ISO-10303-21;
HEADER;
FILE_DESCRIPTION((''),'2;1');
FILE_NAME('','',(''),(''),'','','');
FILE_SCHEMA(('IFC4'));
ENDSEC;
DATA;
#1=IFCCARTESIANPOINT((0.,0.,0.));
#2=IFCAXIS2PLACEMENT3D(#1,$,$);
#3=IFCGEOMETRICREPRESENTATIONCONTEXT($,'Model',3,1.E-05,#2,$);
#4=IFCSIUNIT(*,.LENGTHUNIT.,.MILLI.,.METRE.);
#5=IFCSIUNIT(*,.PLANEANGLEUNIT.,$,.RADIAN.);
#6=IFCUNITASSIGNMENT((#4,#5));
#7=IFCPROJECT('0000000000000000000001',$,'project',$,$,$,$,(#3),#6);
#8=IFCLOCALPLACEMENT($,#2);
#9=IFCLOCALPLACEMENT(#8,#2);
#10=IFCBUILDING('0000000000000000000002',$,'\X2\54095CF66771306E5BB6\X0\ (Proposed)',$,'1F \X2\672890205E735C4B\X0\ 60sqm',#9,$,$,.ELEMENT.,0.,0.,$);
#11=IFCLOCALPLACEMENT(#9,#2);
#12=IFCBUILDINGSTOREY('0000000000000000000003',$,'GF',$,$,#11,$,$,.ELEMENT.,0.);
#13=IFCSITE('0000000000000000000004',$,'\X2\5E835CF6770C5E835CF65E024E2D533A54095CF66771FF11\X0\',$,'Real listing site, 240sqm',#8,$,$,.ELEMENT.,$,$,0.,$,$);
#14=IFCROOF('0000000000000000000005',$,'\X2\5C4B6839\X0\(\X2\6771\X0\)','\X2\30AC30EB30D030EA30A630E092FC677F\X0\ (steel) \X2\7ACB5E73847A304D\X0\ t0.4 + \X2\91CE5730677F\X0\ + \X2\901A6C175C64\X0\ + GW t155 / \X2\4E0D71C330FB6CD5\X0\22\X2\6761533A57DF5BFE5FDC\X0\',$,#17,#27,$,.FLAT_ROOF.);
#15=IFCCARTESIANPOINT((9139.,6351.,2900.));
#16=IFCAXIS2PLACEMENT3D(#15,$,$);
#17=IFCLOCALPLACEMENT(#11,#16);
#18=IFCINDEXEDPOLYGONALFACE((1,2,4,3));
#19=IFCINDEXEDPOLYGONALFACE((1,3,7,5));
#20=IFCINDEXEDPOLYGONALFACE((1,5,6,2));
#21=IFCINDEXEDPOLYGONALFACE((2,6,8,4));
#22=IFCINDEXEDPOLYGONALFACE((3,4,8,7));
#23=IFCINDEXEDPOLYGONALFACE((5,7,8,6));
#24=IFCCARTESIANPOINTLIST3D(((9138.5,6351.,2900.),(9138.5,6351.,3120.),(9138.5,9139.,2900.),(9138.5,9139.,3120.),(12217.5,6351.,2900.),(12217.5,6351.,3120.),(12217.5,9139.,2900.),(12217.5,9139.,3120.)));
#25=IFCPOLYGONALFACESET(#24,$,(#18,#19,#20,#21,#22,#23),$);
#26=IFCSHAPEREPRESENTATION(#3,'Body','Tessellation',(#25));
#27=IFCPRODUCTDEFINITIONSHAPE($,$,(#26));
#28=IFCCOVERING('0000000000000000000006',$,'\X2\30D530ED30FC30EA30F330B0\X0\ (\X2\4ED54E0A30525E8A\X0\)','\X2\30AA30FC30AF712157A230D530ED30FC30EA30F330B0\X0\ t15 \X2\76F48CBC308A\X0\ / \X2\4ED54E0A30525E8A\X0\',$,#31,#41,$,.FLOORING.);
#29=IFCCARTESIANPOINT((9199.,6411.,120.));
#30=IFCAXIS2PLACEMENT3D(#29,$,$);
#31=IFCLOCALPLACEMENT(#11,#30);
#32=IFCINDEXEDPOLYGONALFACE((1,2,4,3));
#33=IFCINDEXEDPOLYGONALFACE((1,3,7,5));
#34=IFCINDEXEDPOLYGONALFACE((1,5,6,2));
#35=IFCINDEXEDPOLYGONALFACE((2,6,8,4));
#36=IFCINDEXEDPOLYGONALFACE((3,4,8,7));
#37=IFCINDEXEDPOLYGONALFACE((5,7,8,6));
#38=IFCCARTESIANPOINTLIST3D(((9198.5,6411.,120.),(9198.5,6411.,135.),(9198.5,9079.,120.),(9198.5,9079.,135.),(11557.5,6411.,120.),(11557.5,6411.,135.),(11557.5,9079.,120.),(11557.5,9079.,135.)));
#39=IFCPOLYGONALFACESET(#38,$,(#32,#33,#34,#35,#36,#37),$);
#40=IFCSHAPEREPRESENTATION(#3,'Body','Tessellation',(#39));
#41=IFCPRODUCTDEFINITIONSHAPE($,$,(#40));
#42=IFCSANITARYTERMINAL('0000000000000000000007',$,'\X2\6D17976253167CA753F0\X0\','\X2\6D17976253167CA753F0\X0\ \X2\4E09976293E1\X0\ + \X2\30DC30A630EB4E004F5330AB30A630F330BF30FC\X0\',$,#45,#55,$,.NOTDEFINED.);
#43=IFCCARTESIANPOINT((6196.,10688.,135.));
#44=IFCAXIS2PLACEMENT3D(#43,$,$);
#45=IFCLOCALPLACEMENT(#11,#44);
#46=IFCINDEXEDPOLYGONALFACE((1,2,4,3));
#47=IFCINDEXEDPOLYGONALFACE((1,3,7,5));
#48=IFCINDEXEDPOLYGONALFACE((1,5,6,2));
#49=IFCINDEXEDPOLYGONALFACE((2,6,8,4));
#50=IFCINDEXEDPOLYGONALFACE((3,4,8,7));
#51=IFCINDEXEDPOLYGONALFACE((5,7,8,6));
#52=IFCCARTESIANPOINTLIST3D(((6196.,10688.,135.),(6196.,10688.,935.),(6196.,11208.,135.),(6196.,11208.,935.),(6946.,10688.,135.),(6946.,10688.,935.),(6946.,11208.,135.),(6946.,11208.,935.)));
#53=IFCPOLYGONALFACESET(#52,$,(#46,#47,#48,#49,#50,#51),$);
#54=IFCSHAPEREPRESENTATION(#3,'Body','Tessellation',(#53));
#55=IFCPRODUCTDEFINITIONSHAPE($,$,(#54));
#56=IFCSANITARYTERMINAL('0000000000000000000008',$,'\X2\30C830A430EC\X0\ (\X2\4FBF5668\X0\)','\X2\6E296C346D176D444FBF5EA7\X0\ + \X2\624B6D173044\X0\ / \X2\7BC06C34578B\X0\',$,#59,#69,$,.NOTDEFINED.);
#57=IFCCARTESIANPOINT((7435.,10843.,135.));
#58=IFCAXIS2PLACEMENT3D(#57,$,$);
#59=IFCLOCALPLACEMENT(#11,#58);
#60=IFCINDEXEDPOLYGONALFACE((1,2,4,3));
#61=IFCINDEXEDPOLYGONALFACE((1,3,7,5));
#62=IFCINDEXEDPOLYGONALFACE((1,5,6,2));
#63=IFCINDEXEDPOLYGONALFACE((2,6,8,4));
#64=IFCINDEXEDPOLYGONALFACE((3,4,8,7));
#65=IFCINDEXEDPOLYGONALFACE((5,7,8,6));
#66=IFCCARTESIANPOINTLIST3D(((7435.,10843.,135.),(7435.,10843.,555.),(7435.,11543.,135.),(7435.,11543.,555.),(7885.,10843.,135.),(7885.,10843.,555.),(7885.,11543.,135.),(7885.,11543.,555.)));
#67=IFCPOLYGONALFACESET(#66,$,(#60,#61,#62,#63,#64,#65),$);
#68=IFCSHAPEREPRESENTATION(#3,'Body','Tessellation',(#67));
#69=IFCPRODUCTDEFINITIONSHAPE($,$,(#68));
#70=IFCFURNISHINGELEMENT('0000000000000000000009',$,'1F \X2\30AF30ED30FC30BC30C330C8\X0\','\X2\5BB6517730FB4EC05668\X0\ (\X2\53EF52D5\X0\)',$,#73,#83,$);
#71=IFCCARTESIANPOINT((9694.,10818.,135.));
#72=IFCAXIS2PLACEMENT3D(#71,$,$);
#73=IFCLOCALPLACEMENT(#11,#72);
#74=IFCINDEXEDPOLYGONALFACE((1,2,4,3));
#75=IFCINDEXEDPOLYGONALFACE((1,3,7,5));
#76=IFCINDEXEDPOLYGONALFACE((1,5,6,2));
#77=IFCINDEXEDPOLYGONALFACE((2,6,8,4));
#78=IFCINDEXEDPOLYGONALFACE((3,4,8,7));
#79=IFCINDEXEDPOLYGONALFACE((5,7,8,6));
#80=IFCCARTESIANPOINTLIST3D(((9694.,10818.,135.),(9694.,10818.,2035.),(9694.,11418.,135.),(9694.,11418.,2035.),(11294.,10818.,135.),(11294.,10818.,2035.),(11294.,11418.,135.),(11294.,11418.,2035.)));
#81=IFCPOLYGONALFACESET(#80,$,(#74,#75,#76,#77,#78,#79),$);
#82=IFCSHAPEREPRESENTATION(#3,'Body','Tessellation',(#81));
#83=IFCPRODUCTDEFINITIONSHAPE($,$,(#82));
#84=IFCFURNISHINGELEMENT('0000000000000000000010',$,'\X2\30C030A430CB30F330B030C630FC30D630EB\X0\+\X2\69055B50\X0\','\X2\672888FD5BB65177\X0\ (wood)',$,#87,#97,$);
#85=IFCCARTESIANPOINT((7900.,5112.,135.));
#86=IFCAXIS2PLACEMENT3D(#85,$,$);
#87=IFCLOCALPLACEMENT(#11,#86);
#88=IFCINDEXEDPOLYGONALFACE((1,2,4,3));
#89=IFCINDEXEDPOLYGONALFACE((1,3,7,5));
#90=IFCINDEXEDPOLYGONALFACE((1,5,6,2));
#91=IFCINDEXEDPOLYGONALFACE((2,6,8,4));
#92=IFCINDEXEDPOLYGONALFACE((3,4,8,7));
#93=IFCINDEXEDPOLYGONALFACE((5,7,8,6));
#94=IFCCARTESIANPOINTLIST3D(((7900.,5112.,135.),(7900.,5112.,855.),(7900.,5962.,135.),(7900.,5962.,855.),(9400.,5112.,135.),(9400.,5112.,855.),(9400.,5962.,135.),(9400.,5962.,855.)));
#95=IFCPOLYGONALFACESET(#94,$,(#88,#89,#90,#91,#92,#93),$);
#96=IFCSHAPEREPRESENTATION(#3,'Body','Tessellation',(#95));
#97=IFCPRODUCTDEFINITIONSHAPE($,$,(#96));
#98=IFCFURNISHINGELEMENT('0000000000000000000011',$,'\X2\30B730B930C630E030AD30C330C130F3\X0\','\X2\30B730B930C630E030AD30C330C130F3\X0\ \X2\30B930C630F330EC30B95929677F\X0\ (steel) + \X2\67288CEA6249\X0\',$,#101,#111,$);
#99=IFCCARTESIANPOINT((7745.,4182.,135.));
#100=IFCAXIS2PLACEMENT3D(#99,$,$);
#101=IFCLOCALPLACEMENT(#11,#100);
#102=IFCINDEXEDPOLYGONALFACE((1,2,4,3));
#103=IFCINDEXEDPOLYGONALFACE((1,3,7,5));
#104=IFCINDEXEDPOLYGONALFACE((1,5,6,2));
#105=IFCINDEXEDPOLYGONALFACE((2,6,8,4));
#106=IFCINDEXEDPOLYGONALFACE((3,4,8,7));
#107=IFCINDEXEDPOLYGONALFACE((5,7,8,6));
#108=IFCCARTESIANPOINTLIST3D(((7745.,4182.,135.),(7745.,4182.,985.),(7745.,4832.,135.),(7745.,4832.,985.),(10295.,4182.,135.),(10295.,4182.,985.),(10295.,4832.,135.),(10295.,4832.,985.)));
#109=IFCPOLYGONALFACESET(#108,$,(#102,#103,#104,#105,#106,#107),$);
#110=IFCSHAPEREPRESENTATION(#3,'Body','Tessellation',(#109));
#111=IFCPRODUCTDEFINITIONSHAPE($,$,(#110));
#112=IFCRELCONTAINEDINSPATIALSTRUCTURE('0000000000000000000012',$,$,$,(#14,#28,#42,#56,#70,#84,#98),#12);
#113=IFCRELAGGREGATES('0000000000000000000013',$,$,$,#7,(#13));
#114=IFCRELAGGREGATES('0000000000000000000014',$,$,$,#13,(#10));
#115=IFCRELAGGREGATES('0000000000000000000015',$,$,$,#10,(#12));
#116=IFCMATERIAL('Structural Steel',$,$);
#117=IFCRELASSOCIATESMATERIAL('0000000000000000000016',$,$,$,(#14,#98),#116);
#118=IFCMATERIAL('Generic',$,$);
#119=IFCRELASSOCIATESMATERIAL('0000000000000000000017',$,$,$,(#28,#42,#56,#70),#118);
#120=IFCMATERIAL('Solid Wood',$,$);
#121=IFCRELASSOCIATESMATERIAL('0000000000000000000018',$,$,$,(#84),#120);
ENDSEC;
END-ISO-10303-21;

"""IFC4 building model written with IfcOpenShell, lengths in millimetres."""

from ifc_helpers import new_model, si_unit, frame, frame_2d, origin, place, context, project, spatial, rectangle, extrude, material, element, save


model = new_model("IFC4")

# Units and contexts
model_context = context("Model", 3, precision=1e-05, world=origin())
ifc_project = project(units=[si_unit("LENGTHUNIT", "METRE", prefix="MILLI"), si_unit("PLANEANGLEUNIT", "RADIAN")], contexts=[model_context])

# Site, building, storey
site_placement = place(None, origin())
site = spatial("IfcSite", under=ifc_project, at=site_placement, Name="広島県広島市中区吉島東１", ObjectType="Real listing site, 240sqm", CompositionType="ELEMENT", RefElevation=0.0)
building_placement = place(site_placement, origin())
building = spatial("IfcBuilding", under=site, at=building_placement, Name="吉島東の家 (Proposed)", ObjectType="1F 木造平屋 60sqm", CompositionType="ELEMENT", ElevationOfRefHeight=0.0, ElevationOfTerrain=0.0)
storey_placement = place(building_placement, origin())
storey = spatial("IfcBuildingStorey", under=building, at=storey_placement, Name="GF", CompositionType="ELEMENT", Elevation=0.0)

# Shared definitions
ifc_material_1 = material(Name="Solid Wood")

# Roof
ifc_material_2 = material(Name="Structural Steel")
roof_placement = place(storey_placement, frame((9139.0, 6351.0, 2900.0)))
element("IfcRoof", 1, at=roof_placement, inside=storey, material=ifc_material_2, Name="屋根(東)", Description="ガルバリウム鋼板 (steel) 立平葺き t0.4 + 野地板 + 通気層 + GW t155 / 不燃・法22条区域対応", PredefinedType="FLAT_ROOF", context=model_context, shape_type="SweptSolid", body=[
    extrude(rectangle(XDim=3079.0, YDim=2788.0, at=frame_2d((1539.0, 1394.0))), frame((9139.0, 6351.0, 2900.0)), (0.0, 0.0, 1.0), 220.0),
])

# Covering
ifc_material_3 = material(Name="Generic")
covering_placement = place(storey_placement, frame((9199.0, 6411.0, 120.0)))
element("IfcCovering", 2, at=covering_placement, inside=storey, material=ifc_material_3, Name="フローリング (仕上げ床)", Description="オーク無垢フローリング t15 直貼り / 仕上げ床", PredefinedType="FLOORING", context=model_context, shape_type="SweptSolid", body=[
    extrude(rectangle(XDim=2359.0, YDim=2668.0, at=frame_2d((1179.0, 1334.0))), frame((9199.0, 6411.0, 120.0)), (0.0, 0.0, 1.0), 15.0),
])

# Sanitary terminals
sanitary_terminal_1_placement = place(storey_placement, frame((6196.0, 10688.0, 135.0)))
element("IfcSanitaryTerminal", 3, at=sanitary_terminal_1_placement, inside=storey, material=ifc_material_3, Name="洗面化粧台", Description="洗面化粧台 三面鏡 + ボウル一体カウンター", PredefinedType="NOTDEFINED", context=model_context, shape_type="SweptSolid", body=[
    extrude(rectangle(XDim=750.0, YDim=520.0, at=frame_2d((375.0, 260.0))), frame((6196.0, 10688.0, 135.0)), (0.0, 0.0, 1.0), 800.0),
])
sanitary_terminal_2_placement = place(storey_placement, frame((7435.0, 10843.0, 135.0)))
element("IfcSanitaryTerminal", 4, at=sanitary_terminal_2_placement, inside=storey, material=ifc_material_3, Name="トイレ (便器)", Description="温水洗浄便座 + 手洗い / 節水型", PredefinedType="NOTDEFINED", context=model_context, shape_type="SweptSolid", body=[
    extrude(rectangle(XDim=450.0, YDim=700.0, at=frame_2d((225.0, 350.0))), frame((7435.0, 10843.0, 135.0)), (0.0, 0.0, 1.0), 420.0),
])

# Furnishing elements
furnishing_1_placement = place(storey_placement, frame((9694.0, 10818.0, 135.0)))
element("IfcFurnishingElement", 5, at=furnishing_1_placement, inside=storey, material=ifc_material_3, Name="1F クローゼット", Description="家具・什器 (可動)", context=model_context, shape_type="SweptSolid", body=[
    extrude(rectangle(XDim=1600.0, YDim=600.0, at=frame_2d((800.0, 300.0))), frame((9694.0, 10818.0, 135.0)), (0.0, 0.0, 1.0), 1900.0),
])
furnishing_2_placement = place(storey_placement, frame((7900.0, 5112.0, 135.0)))
element("IfcFurnishingElement", 6, at=furnishing_2_placement, inside=storey, material=ifc_material_1, Name="ダイニングテーブル+椅子", Description="木製家具 (wood)", context=model_context, shape_type="SweptSolid", body=[
    extrude(rectangle(XDim=1500.0, YDim=850.0, at=frame_2d((750.0, 425.0))), frame((7900.0, 5112.0, 135.0)), (0.0, 0.0, 1.0), 720.0),
])
furnishing_3_placement = place(storey_placement, frame((7745.0, 4182.0, 135.0)))
element("IfcFurnishingElement", 7, at=furnishing_3_placement, inside=storey, material=ifc_material_2, Name="システムキッチン", Description="システムキッチン ステンレス天板 (steel) + 木質扉", context=model_context, shape_type="SweptSolid", body=[
    extrude(rectangle(XDim=2550.0, YDim=650.0, at=frame_2d((1275.0, 325.0))), frame((7745.0, 4182.0, 135.0)), (0.0, 0.0, 1.0), 850.0),
])

save(model, "model.ifc")
